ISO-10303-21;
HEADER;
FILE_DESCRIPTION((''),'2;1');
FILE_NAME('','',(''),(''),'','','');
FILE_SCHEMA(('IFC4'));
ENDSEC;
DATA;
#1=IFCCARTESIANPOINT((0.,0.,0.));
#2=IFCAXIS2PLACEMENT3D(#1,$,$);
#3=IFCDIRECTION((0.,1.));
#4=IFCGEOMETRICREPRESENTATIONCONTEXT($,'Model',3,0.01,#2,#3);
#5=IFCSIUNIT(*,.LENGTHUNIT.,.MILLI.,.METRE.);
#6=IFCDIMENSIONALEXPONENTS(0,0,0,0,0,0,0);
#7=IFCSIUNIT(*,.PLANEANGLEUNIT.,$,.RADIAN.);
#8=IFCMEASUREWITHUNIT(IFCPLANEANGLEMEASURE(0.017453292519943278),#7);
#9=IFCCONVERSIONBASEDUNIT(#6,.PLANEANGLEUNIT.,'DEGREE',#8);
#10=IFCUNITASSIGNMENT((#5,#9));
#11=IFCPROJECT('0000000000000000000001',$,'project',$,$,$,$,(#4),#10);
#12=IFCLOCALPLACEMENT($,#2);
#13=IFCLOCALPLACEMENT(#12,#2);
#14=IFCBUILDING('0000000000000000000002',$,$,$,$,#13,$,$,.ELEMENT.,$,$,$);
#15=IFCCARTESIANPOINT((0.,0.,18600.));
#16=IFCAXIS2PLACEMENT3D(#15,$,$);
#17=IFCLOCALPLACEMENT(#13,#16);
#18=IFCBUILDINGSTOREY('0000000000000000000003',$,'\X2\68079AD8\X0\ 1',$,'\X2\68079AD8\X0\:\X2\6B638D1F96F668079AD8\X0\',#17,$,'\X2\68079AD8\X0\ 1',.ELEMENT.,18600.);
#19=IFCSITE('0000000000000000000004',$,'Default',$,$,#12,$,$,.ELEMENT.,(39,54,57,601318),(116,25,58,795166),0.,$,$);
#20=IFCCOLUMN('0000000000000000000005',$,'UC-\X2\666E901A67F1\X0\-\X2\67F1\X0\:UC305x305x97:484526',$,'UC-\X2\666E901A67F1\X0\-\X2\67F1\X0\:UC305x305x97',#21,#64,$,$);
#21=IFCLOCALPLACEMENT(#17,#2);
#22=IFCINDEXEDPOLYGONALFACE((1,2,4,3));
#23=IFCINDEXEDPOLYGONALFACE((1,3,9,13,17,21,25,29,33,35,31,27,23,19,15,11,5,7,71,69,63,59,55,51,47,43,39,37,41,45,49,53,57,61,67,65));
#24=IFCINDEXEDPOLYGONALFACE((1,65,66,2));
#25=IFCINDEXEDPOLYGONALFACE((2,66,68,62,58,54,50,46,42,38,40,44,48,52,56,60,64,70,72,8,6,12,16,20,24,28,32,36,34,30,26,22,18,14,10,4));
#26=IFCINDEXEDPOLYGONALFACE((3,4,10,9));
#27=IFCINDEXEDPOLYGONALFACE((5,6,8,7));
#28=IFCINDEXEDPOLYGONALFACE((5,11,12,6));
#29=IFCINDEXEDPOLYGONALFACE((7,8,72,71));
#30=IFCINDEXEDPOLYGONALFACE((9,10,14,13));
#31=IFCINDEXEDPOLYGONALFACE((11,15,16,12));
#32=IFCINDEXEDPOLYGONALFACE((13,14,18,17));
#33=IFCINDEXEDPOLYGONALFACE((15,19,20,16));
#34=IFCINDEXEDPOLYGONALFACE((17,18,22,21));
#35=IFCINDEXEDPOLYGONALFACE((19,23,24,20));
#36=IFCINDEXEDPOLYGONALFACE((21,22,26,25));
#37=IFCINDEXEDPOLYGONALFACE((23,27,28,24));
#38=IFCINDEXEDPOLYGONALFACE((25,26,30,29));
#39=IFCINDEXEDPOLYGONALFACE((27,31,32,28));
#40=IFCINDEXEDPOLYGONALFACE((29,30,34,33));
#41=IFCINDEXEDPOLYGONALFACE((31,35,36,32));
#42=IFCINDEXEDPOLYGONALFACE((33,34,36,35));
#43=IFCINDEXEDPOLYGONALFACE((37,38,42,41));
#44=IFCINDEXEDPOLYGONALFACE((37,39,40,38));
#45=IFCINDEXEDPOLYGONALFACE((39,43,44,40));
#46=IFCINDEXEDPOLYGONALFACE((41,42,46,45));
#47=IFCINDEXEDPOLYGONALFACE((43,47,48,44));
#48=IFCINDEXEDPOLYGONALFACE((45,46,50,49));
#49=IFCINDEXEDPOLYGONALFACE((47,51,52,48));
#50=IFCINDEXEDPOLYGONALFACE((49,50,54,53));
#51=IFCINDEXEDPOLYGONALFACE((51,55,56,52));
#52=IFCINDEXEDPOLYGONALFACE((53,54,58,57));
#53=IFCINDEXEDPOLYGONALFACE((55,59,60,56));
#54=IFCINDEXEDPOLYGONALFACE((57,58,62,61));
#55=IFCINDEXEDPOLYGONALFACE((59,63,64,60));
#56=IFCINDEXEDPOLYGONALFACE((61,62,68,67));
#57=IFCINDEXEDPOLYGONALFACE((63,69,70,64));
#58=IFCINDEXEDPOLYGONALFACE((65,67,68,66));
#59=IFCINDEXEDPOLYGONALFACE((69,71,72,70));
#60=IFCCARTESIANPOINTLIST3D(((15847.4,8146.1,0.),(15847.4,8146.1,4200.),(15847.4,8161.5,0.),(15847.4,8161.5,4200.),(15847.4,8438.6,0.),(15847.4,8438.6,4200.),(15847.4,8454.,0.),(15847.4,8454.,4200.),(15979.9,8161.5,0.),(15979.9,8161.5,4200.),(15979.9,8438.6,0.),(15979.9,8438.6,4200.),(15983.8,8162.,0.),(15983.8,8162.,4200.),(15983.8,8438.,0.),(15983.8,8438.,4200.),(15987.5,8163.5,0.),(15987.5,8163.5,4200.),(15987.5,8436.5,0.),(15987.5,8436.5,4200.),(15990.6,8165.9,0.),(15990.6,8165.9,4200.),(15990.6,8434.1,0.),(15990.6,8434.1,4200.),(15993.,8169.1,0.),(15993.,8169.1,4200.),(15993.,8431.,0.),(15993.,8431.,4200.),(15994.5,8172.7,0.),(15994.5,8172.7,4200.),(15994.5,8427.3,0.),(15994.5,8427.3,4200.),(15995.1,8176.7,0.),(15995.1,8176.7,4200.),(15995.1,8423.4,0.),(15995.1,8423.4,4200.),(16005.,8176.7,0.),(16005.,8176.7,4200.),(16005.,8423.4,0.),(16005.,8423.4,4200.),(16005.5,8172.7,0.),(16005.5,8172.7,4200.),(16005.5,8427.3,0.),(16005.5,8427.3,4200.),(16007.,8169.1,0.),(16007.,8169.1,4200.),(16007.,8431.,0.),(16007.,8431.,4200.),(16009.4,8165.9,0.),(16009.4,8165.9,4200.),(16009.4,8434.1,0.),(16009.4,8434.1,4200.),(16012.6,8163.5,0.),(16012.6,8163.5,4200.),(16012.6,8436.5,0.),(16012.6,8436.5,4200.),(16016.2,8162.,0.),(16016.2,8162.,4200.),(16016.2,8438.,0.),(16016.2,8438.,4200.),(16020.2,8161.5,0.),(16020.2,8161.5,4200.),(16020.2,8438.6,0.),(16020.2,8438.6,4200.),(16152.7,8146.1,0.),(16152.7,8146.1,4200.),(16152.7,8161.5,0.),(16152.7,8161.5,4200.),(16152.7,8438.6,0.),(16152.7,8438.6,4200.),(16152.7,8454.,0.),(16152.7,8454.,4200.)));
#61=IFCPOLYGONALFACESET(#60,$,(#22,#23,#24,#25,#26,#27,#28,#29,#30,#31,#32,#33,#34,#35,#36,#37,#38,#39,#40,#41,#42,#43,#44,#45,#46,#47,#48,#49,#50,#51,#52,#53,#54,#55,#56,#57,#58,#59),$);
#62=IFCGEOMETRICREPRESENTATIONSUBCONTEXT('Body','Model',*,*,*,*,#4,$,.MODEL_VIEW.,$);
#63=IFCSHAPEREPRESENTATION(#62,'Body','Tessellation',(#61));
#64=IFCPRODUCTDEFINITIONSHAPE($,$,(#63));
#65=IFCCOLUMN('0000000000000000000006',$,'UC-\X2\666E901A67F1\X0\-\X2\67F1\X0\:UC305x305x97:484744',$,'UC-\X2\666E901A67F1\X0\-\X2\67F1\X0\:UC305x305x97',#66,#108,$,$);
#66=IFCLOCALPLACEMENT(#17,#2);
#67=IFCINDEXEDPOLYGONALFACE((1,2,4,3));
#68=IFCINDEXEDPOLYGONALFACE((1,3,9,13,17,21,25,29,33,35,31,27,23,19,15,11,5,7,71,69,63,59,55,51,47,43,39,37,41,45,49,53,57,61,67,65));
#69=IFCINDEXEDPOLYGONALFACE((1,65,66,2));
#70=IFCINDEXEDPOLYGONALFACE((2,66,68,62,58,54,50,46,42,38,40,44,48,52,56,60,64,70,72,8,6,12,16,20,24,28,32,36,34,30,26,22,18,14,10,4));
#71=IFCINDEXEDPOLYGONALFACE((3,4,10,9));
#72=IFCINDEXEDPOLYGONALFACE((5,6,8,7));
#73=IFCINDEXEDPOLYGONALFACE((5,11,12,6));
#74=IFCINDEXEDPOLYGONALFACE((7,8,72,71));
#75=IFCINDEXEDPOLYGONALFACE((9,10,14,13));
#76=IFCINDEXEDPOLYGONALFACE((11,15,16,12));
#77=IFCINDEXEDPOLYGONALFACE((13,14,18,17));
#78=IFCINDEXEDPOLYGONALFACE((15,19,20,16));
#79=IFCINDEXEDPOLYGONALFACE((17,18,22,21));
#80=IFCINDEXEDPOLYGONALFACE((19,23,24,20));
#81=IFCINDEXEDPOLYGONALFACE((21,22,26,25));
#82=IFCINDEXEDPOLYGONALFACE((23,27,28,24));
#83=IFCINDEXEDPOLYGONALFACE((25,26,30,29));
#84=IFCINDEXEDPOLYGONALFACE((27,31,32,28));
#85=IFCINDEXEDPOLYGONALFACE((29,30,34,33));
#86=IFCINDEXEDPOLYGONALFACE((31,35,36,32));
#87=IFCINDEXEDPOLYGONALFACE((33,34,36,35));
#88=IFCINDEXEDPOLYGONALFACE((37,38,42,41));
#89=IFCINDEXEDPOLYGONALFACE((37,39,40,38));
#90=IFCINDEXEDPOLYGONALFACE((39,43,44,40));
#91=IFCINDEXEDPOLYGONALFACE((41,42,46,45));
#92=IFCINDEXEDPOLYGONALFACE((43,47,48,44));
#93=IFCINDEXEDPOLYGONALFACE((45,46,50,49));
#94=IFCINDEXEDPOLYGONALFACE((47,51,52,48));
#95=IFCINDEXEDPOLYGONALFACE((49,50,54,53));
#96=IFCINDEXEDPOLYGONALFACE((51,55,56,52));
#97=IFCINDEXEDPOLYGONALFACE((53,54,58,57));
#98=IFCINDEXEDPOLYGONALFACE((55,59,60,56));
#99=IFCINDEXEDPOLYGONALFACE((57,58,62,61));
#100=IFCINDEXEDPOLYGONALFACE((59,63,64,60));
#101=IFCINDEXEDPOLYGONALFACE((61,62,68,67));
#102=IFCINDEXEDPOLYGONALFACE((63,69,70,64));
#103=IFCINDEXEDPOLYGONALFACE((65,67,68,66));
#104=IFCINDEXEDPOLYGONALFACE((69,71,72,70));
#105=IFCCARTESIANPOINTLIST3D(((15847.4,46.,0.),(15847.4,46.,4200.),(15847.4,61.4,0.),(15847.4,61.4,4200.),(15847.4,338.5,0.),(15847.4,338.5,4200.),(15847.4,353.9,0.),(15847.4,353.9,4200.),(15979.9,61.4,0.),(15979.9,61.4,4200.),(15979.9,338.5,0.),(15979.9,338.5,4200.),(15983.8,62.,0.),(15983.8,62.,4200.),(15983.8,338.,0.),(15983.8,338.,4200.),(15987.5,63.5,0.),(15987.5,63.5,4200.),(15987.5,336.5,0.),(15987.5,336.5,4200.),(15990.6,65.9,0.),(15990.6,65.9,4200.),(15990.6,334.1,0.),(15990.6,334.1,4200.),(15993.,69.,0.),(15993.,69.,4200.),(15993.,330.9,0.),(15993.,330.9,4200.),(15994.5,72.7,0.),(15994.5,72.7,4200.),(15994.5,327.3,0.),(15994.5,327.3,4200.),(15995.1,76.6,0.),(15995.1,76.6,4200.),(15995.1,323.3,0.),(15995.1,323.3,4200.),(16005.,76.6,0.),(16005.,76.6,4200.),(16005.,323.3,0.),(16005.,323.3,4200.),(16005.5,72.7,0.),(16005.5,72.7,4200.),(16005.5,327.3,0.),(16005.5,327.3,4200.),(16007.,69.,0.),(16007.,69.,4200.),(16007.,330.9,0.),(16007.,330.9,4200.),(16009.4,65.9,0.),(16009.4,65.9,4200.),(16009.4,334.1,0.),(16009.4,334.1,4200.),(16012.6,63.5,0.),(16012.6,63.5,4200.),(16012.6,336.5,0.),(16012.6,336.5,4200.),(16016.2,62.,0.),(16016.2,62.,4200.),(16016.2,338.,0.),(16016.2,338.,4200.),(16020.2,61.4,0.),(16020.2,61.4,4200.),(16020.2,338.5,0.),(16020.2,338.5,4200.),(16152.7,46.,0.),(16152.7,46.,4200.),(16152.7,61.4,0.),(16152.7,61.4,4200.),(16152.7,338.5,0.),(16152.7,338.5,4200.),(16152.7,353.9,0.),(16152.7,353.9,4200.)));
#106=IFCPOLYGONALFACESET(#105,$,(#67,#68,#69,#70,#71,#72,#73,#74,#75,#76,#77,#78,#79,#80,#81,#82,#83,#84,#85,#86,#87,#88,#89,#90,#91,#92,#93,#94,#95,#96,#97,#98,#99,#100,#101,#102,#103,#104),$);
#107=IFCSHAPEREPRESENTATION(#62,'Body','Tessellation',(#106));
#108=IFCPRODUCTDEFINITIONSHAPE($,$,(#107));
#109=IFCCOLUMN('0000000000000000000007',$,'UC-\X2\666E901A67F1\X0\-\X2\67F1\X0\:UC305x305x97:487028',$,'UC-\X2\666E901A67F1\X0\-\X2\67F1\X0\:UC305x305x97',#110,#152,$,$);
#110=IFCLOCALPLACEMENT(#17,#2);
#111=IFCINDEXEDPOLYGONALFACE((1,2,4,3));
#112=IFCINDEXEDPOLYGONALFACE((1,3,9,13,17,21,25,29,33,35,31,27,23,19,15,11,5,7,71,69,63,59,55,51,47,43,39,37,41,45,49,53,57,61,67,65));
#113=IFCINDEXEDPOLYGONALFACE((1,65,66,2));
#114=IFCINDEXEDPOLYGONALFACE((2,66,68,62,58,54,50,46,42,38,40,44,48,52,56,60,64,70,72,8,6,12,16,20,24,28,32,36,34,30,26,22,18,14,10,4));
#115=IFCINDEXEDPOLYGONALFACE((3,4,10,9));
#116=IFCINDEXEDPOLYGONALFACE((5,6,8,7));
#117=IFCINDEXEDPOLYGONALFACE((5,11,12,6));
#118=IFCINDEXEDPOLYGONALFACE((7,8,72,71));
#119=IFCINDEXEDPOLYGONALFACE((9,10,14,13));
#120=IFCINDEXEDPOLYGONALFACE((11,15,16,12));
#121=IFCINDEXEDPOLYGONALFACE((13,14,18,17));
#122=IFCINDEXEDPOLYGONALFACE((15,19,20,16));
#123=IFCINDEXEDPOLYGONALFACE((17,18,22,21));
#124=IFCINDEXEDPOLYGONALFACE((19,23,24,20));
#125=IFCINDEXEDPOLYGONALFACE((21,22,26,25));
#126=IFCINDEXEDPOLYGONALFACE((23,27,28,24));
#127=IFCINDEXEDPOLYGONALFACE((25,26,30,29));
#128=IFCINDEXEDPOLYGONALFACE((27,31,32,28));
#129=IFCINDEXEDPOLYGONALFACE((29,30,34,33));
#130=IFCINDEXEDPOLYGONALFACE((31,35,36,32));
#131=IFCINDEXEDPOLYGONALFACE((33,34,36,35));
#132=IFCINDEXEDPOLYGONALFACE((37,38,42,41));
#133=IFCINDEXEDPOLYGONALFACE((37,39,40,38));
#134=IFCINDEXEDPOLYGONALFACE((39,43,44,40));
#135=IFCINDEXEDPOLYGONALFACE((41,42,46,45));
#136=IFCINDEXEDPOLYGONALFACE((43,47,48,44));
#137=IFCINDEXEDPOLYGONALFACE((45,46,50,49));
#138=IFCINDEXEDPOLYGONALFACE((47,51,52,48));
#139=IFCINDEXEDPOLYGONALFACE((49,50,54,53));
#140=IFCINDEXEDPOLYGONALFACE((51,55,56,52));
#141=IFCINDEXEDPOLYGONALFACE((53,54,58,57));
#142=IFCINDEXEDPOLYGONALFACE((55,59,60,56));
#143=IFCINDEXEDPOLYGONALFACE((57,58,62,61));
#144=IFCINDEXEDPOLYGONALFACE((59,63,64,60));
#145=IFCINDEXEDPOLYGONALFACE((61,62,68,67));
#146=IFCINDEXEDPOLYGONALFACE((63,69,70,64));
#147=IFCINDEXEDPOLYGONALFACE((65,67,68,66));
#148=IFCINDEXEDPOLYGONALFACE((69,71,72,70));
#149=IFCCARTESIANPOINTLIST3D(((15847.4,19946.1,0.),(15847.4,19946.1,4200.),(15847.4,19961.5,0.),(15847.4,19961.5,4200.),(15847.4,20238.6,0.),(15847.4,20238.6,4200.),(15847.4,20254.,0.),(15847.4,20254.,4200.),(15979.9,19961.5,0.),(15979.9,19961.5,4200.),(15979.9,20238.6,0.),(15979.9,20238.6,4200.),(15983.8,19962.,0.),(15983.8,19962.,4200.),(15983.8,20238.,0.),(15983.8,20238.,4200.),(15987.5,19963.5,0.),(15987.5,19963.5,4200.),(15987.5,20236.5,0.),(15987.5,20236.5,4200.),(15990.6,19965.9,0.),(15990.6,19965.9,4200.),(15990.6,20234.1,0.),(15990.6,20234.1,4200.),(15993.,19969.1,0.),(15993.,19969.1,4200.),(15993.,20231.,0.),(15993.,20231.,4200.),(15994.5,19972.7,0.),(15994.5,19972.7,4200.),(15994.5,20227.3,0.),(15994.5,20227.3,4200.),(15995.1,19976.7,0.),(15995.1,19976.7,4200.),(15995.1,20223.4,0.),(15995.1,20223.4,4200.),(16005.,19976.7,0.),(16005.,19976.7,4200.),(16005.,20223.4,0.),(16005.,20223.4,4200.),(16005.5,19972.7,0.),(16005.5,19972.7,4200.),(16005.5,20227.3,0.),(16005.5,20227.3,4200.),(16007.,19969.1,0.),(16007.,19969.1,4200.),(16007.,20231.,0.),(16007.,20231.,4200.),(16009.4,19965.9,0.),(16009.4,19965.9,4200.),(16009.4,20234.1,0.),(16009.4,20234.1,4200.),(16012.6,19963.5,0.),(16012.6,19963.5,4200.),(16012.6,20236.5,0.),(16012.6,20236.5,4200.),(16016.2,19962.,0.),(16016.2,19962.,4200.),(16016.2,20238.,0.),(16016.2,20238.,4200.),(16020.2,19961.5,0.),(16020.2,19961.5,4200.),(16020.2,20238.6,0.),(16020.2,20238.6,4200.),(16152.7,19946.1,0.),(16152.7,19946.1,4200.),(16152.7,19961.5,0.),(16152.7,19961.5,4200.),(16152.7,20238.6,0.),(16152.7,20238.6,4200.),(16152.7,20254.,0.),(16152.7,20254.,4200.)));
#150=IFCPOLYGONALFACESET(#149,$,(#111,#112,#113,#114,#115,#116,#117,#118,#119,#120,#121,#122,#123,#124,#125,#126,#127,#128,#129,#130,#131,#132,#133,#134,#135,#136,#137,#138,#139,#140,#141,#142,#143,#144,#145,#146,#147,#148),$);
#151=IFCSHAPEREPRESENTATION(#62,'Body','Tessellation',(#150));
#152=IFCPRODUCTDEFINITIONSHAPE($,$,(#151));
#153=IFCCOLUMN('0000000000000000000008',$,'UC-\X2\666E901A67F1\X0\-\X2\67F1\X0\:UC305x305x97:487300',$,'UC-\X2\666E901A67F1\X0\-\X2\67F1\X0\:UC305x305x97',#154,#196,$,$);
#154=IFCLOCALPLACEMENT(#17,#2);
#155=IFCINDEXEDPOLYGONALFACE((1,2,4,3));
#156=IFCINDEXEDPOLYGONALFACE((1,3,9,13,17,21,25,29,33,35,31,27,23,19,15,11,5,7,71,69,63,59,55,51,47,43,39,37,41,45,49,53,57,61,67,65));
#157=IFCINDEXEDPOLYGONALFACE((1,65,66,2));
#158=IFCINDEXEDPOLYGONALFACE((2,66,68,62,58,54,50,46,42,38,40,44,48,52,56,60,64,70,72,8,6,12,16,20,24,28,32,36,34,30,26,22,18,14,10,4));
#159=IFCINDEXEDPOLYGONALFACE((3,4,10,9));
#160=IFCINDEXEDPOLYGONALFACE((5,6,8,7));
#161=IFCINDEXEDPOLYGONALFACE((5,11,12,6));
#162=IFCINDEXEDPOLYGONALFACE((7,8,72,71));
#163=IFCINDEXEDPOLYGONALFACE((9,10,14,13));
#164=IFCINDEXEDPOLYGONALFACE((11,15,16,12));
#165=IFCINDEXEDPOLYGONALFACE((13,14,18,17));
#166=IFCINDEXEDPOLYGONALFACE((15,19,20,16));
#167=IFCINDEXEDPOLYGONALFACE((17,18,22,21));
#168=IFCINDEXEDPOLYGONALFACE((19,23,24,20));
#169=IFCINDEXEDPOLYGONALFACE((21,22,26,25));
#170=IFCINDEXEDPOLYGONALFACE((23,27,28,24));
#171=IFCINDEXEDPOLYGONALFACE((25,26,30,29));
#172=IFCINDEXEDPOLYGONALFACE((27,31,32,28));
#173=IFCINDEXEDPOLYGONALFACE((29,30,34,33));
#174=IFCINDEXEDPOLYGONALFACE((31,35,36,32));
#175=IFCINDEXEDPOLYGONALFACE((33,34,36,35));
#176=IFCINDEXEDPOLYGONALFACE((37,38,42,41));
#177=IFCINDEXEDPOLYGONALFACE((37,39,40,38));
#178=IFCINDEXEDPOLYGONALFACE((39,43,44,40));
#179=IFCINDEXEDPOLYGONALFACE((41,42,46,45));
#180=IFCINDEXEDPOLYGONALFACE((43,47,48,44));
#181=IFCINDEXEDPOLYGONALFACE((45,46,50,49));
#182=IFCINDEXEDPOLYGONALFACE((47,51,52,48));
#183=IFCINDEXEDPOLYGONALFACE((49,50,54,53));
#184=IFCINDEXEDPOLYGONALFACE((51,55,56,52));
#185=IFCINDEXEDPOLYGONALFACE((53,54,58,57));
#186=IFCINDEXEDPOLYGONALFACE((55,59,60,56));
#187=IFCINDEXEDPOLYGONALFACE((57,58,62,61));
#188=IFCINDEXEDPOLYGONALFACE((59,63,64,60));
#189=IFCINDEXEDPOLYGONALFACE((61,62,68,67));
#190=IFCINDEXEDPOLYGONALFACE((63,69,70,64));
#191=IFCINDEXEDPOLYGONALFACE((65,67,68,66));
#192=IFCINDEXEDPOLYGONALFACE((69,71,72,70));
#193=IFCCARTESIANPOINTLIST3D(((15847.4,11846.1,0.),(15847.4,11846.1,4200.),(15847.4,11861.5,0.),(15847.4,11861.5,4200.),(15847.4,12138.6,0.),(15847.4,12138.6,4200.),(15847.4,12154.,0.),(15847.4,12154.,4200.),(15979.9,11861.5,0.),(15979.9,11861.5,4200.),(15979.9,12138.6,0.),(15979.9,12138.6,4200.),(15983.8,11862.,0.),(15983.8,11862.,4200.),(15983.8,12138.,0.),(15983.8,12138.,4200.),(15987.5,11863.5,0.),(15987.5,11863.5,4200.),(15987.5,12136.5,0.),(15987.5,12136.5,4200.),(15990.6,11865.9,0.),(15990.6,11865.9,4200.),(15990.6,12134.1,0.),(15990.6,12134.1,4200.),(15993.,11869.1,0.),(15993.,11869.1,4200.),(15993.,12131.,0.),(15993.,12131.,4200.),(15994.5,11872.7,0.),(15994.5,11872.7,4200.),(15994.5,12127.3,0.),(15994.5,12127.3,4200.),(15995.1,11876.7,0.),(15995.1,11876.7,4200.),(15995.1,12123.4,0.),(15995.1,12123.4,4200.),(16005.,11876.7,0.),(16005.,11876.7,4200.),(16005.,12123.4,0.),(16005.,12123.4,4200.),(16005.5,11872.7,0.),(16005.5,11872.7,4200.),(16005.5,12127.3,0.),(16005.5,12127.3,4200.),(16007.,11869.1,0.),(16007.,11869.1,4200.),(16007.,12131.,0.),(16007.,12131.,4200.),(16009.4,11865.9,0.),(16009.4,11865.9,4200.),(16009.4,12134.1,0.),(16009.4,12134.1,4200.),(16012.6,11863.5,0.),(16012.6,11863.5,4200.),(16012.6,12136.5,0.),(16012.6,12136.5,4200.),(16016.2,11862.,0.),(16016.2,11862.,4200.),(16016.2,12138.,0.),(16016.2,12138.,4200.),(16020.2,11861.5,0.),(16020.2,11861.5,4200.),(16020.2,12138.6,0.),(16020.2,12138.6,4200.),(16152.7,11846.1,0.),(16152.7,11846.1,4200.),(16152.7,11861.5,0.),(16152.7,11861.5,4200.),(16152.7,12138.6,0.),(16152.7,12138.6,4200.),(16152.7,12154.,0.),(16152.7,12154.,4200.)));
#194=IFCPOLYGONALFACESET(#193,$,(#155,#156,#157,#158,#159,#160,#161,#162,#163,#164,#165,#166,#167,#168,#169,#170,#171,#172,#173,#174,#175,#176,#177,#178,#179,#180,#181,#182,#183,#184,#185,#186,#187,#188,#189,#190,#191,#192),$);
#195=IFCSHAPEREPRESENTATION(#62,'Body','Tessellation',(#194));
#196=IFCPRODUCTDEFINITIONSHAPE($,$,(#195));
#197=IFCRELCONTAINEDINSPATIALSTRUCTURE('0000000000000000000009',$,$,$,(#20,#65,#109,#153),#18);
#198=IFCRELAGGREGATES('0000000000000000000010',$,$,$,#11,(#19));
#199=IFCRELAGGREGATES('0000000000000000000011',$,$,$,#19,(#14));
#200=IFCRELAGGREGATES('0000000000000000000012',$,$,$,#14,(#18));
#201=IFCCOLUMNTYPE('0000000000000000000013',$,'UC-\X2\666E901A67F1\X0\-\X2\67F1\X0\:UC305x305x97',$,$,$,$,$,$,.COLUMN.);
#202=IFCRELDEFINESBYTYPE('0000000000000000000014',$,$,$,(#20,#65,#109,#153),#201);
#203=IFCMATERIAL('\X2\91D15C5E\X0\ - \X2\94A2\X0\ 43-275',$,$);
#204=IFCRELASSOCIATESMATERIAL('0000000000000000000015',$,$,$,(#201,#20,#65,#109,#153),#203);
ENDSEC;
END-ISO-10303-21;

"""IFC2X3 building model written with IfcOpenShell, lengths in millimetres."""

from ifc_helpers import new_model, entity, si_unit, converted_unit, direction, frame, origin, origin_2d_with_axis, place, context, subcontext, project, spatial, i_section, extrude, source, transform, mapped, material, type_object, type_shapes, element, save


model = new_model("IFC2X3")

# Units and contexts
model_context = context("Model", 3, precision=0.01, world=origin(), true_north=direction((0.0, 1.0)))
body_context = subcontext(model_context, "Body", "Model", "MODEL_VIEW")
ifc_project = project(units=[si_unit("LENGTHUNIT", "METRE", prefix="MILLI"), converted_unit("PLANEANGLEUNIT", "DEGREE", entity("IfcPlaneAngleMeasure", 0.017453292519943278), si_unit("PLANEANGLEUNIT", "RADIAN"), dimensions=[0, 0, 0, 0, 0, 0, 0])], contexts=[model_context])

# Site, building, storey
site_placement = place(None, origin())
site = spatial("IfcSite", under=ifc_project, at=site_placement, Name="Default", CompositionType="ELEMENT", RefLatitude=(39, 54, 57, 601318), RefLongitude=(116, 25, 58, 795166), RefElevation=0.0)
building_placement = place(site_placement, origin())
building = spatial("IfcBuilding", under=site, at=building_placement, CompositionType="ELEMENT")
storey_placement = place(building_placement, frame((0.0, 0.0, 18600.0)))
storey = spatial("IfcBuildingStorey", under=building, at=storey_placement, Name="标高 1", ObjectType="标高:正负零标高", LongName="标高 1", CompositionType="ELEMENT", Elevation=18600.0)

# Columns
ifc_material_1 = material(Name="金属 - 钢 43-275")
column_type = type_object("IfcColumnType", Name="UC-普通柱-柱:UC305x305x97", PredefinedType="COLUMN", material=ifc_material_1)
shared_shape = source(origin(), body_context, "Body", "SweptSolid", [
    extrude(i_section(OverallWidth=305.3, OverallDepth=307.9, WebThickness=9.9, FlangeThickness=15.4, FilletRadius=15.2, at=origin_2d_with_axis()), frame((0.0, 0.0, 18600.0), z_axis=(0.0, 0.0, 1.0), x_axis=(-1.0, 0.0, 0.0)), (0.0, 0.0, 1.0), 4200.0),
])
type_shapes(column_type, [shared_shape])
for number, where, name in (
    (1, (16000.0, 8300.0, -18600.0), "UC-普通柱-柱:UC305x305x97:484526"),
    (2, (16000.0, 200.0, -18600.0), "UC-普通柱-柱:UC305x305x97:484744"),
    (3, (16000.0, 20100.0, -18600.0), "UC-普通柱-柱:UC305x305x97:487028"),
    (4, (16000.0, 12000.0, -18600.0), "UC-普通柱-柱:UC305x305x97:487300"),
):
    element("IfcColumn", number, at=place(storey_placement, frame(where)), inside=storey, type_object=column_type, material=ifc_material_1, Name=name, ObjectType="UC-普通柱-柱:UC305x305x97", context=body_context, shape_type="MappedRepresentation", body=[
        mapped(shared_shape, transform((0.0, 0.0, 0.0), scale=1.0)),
    ])

save(model, "model.ifc")
